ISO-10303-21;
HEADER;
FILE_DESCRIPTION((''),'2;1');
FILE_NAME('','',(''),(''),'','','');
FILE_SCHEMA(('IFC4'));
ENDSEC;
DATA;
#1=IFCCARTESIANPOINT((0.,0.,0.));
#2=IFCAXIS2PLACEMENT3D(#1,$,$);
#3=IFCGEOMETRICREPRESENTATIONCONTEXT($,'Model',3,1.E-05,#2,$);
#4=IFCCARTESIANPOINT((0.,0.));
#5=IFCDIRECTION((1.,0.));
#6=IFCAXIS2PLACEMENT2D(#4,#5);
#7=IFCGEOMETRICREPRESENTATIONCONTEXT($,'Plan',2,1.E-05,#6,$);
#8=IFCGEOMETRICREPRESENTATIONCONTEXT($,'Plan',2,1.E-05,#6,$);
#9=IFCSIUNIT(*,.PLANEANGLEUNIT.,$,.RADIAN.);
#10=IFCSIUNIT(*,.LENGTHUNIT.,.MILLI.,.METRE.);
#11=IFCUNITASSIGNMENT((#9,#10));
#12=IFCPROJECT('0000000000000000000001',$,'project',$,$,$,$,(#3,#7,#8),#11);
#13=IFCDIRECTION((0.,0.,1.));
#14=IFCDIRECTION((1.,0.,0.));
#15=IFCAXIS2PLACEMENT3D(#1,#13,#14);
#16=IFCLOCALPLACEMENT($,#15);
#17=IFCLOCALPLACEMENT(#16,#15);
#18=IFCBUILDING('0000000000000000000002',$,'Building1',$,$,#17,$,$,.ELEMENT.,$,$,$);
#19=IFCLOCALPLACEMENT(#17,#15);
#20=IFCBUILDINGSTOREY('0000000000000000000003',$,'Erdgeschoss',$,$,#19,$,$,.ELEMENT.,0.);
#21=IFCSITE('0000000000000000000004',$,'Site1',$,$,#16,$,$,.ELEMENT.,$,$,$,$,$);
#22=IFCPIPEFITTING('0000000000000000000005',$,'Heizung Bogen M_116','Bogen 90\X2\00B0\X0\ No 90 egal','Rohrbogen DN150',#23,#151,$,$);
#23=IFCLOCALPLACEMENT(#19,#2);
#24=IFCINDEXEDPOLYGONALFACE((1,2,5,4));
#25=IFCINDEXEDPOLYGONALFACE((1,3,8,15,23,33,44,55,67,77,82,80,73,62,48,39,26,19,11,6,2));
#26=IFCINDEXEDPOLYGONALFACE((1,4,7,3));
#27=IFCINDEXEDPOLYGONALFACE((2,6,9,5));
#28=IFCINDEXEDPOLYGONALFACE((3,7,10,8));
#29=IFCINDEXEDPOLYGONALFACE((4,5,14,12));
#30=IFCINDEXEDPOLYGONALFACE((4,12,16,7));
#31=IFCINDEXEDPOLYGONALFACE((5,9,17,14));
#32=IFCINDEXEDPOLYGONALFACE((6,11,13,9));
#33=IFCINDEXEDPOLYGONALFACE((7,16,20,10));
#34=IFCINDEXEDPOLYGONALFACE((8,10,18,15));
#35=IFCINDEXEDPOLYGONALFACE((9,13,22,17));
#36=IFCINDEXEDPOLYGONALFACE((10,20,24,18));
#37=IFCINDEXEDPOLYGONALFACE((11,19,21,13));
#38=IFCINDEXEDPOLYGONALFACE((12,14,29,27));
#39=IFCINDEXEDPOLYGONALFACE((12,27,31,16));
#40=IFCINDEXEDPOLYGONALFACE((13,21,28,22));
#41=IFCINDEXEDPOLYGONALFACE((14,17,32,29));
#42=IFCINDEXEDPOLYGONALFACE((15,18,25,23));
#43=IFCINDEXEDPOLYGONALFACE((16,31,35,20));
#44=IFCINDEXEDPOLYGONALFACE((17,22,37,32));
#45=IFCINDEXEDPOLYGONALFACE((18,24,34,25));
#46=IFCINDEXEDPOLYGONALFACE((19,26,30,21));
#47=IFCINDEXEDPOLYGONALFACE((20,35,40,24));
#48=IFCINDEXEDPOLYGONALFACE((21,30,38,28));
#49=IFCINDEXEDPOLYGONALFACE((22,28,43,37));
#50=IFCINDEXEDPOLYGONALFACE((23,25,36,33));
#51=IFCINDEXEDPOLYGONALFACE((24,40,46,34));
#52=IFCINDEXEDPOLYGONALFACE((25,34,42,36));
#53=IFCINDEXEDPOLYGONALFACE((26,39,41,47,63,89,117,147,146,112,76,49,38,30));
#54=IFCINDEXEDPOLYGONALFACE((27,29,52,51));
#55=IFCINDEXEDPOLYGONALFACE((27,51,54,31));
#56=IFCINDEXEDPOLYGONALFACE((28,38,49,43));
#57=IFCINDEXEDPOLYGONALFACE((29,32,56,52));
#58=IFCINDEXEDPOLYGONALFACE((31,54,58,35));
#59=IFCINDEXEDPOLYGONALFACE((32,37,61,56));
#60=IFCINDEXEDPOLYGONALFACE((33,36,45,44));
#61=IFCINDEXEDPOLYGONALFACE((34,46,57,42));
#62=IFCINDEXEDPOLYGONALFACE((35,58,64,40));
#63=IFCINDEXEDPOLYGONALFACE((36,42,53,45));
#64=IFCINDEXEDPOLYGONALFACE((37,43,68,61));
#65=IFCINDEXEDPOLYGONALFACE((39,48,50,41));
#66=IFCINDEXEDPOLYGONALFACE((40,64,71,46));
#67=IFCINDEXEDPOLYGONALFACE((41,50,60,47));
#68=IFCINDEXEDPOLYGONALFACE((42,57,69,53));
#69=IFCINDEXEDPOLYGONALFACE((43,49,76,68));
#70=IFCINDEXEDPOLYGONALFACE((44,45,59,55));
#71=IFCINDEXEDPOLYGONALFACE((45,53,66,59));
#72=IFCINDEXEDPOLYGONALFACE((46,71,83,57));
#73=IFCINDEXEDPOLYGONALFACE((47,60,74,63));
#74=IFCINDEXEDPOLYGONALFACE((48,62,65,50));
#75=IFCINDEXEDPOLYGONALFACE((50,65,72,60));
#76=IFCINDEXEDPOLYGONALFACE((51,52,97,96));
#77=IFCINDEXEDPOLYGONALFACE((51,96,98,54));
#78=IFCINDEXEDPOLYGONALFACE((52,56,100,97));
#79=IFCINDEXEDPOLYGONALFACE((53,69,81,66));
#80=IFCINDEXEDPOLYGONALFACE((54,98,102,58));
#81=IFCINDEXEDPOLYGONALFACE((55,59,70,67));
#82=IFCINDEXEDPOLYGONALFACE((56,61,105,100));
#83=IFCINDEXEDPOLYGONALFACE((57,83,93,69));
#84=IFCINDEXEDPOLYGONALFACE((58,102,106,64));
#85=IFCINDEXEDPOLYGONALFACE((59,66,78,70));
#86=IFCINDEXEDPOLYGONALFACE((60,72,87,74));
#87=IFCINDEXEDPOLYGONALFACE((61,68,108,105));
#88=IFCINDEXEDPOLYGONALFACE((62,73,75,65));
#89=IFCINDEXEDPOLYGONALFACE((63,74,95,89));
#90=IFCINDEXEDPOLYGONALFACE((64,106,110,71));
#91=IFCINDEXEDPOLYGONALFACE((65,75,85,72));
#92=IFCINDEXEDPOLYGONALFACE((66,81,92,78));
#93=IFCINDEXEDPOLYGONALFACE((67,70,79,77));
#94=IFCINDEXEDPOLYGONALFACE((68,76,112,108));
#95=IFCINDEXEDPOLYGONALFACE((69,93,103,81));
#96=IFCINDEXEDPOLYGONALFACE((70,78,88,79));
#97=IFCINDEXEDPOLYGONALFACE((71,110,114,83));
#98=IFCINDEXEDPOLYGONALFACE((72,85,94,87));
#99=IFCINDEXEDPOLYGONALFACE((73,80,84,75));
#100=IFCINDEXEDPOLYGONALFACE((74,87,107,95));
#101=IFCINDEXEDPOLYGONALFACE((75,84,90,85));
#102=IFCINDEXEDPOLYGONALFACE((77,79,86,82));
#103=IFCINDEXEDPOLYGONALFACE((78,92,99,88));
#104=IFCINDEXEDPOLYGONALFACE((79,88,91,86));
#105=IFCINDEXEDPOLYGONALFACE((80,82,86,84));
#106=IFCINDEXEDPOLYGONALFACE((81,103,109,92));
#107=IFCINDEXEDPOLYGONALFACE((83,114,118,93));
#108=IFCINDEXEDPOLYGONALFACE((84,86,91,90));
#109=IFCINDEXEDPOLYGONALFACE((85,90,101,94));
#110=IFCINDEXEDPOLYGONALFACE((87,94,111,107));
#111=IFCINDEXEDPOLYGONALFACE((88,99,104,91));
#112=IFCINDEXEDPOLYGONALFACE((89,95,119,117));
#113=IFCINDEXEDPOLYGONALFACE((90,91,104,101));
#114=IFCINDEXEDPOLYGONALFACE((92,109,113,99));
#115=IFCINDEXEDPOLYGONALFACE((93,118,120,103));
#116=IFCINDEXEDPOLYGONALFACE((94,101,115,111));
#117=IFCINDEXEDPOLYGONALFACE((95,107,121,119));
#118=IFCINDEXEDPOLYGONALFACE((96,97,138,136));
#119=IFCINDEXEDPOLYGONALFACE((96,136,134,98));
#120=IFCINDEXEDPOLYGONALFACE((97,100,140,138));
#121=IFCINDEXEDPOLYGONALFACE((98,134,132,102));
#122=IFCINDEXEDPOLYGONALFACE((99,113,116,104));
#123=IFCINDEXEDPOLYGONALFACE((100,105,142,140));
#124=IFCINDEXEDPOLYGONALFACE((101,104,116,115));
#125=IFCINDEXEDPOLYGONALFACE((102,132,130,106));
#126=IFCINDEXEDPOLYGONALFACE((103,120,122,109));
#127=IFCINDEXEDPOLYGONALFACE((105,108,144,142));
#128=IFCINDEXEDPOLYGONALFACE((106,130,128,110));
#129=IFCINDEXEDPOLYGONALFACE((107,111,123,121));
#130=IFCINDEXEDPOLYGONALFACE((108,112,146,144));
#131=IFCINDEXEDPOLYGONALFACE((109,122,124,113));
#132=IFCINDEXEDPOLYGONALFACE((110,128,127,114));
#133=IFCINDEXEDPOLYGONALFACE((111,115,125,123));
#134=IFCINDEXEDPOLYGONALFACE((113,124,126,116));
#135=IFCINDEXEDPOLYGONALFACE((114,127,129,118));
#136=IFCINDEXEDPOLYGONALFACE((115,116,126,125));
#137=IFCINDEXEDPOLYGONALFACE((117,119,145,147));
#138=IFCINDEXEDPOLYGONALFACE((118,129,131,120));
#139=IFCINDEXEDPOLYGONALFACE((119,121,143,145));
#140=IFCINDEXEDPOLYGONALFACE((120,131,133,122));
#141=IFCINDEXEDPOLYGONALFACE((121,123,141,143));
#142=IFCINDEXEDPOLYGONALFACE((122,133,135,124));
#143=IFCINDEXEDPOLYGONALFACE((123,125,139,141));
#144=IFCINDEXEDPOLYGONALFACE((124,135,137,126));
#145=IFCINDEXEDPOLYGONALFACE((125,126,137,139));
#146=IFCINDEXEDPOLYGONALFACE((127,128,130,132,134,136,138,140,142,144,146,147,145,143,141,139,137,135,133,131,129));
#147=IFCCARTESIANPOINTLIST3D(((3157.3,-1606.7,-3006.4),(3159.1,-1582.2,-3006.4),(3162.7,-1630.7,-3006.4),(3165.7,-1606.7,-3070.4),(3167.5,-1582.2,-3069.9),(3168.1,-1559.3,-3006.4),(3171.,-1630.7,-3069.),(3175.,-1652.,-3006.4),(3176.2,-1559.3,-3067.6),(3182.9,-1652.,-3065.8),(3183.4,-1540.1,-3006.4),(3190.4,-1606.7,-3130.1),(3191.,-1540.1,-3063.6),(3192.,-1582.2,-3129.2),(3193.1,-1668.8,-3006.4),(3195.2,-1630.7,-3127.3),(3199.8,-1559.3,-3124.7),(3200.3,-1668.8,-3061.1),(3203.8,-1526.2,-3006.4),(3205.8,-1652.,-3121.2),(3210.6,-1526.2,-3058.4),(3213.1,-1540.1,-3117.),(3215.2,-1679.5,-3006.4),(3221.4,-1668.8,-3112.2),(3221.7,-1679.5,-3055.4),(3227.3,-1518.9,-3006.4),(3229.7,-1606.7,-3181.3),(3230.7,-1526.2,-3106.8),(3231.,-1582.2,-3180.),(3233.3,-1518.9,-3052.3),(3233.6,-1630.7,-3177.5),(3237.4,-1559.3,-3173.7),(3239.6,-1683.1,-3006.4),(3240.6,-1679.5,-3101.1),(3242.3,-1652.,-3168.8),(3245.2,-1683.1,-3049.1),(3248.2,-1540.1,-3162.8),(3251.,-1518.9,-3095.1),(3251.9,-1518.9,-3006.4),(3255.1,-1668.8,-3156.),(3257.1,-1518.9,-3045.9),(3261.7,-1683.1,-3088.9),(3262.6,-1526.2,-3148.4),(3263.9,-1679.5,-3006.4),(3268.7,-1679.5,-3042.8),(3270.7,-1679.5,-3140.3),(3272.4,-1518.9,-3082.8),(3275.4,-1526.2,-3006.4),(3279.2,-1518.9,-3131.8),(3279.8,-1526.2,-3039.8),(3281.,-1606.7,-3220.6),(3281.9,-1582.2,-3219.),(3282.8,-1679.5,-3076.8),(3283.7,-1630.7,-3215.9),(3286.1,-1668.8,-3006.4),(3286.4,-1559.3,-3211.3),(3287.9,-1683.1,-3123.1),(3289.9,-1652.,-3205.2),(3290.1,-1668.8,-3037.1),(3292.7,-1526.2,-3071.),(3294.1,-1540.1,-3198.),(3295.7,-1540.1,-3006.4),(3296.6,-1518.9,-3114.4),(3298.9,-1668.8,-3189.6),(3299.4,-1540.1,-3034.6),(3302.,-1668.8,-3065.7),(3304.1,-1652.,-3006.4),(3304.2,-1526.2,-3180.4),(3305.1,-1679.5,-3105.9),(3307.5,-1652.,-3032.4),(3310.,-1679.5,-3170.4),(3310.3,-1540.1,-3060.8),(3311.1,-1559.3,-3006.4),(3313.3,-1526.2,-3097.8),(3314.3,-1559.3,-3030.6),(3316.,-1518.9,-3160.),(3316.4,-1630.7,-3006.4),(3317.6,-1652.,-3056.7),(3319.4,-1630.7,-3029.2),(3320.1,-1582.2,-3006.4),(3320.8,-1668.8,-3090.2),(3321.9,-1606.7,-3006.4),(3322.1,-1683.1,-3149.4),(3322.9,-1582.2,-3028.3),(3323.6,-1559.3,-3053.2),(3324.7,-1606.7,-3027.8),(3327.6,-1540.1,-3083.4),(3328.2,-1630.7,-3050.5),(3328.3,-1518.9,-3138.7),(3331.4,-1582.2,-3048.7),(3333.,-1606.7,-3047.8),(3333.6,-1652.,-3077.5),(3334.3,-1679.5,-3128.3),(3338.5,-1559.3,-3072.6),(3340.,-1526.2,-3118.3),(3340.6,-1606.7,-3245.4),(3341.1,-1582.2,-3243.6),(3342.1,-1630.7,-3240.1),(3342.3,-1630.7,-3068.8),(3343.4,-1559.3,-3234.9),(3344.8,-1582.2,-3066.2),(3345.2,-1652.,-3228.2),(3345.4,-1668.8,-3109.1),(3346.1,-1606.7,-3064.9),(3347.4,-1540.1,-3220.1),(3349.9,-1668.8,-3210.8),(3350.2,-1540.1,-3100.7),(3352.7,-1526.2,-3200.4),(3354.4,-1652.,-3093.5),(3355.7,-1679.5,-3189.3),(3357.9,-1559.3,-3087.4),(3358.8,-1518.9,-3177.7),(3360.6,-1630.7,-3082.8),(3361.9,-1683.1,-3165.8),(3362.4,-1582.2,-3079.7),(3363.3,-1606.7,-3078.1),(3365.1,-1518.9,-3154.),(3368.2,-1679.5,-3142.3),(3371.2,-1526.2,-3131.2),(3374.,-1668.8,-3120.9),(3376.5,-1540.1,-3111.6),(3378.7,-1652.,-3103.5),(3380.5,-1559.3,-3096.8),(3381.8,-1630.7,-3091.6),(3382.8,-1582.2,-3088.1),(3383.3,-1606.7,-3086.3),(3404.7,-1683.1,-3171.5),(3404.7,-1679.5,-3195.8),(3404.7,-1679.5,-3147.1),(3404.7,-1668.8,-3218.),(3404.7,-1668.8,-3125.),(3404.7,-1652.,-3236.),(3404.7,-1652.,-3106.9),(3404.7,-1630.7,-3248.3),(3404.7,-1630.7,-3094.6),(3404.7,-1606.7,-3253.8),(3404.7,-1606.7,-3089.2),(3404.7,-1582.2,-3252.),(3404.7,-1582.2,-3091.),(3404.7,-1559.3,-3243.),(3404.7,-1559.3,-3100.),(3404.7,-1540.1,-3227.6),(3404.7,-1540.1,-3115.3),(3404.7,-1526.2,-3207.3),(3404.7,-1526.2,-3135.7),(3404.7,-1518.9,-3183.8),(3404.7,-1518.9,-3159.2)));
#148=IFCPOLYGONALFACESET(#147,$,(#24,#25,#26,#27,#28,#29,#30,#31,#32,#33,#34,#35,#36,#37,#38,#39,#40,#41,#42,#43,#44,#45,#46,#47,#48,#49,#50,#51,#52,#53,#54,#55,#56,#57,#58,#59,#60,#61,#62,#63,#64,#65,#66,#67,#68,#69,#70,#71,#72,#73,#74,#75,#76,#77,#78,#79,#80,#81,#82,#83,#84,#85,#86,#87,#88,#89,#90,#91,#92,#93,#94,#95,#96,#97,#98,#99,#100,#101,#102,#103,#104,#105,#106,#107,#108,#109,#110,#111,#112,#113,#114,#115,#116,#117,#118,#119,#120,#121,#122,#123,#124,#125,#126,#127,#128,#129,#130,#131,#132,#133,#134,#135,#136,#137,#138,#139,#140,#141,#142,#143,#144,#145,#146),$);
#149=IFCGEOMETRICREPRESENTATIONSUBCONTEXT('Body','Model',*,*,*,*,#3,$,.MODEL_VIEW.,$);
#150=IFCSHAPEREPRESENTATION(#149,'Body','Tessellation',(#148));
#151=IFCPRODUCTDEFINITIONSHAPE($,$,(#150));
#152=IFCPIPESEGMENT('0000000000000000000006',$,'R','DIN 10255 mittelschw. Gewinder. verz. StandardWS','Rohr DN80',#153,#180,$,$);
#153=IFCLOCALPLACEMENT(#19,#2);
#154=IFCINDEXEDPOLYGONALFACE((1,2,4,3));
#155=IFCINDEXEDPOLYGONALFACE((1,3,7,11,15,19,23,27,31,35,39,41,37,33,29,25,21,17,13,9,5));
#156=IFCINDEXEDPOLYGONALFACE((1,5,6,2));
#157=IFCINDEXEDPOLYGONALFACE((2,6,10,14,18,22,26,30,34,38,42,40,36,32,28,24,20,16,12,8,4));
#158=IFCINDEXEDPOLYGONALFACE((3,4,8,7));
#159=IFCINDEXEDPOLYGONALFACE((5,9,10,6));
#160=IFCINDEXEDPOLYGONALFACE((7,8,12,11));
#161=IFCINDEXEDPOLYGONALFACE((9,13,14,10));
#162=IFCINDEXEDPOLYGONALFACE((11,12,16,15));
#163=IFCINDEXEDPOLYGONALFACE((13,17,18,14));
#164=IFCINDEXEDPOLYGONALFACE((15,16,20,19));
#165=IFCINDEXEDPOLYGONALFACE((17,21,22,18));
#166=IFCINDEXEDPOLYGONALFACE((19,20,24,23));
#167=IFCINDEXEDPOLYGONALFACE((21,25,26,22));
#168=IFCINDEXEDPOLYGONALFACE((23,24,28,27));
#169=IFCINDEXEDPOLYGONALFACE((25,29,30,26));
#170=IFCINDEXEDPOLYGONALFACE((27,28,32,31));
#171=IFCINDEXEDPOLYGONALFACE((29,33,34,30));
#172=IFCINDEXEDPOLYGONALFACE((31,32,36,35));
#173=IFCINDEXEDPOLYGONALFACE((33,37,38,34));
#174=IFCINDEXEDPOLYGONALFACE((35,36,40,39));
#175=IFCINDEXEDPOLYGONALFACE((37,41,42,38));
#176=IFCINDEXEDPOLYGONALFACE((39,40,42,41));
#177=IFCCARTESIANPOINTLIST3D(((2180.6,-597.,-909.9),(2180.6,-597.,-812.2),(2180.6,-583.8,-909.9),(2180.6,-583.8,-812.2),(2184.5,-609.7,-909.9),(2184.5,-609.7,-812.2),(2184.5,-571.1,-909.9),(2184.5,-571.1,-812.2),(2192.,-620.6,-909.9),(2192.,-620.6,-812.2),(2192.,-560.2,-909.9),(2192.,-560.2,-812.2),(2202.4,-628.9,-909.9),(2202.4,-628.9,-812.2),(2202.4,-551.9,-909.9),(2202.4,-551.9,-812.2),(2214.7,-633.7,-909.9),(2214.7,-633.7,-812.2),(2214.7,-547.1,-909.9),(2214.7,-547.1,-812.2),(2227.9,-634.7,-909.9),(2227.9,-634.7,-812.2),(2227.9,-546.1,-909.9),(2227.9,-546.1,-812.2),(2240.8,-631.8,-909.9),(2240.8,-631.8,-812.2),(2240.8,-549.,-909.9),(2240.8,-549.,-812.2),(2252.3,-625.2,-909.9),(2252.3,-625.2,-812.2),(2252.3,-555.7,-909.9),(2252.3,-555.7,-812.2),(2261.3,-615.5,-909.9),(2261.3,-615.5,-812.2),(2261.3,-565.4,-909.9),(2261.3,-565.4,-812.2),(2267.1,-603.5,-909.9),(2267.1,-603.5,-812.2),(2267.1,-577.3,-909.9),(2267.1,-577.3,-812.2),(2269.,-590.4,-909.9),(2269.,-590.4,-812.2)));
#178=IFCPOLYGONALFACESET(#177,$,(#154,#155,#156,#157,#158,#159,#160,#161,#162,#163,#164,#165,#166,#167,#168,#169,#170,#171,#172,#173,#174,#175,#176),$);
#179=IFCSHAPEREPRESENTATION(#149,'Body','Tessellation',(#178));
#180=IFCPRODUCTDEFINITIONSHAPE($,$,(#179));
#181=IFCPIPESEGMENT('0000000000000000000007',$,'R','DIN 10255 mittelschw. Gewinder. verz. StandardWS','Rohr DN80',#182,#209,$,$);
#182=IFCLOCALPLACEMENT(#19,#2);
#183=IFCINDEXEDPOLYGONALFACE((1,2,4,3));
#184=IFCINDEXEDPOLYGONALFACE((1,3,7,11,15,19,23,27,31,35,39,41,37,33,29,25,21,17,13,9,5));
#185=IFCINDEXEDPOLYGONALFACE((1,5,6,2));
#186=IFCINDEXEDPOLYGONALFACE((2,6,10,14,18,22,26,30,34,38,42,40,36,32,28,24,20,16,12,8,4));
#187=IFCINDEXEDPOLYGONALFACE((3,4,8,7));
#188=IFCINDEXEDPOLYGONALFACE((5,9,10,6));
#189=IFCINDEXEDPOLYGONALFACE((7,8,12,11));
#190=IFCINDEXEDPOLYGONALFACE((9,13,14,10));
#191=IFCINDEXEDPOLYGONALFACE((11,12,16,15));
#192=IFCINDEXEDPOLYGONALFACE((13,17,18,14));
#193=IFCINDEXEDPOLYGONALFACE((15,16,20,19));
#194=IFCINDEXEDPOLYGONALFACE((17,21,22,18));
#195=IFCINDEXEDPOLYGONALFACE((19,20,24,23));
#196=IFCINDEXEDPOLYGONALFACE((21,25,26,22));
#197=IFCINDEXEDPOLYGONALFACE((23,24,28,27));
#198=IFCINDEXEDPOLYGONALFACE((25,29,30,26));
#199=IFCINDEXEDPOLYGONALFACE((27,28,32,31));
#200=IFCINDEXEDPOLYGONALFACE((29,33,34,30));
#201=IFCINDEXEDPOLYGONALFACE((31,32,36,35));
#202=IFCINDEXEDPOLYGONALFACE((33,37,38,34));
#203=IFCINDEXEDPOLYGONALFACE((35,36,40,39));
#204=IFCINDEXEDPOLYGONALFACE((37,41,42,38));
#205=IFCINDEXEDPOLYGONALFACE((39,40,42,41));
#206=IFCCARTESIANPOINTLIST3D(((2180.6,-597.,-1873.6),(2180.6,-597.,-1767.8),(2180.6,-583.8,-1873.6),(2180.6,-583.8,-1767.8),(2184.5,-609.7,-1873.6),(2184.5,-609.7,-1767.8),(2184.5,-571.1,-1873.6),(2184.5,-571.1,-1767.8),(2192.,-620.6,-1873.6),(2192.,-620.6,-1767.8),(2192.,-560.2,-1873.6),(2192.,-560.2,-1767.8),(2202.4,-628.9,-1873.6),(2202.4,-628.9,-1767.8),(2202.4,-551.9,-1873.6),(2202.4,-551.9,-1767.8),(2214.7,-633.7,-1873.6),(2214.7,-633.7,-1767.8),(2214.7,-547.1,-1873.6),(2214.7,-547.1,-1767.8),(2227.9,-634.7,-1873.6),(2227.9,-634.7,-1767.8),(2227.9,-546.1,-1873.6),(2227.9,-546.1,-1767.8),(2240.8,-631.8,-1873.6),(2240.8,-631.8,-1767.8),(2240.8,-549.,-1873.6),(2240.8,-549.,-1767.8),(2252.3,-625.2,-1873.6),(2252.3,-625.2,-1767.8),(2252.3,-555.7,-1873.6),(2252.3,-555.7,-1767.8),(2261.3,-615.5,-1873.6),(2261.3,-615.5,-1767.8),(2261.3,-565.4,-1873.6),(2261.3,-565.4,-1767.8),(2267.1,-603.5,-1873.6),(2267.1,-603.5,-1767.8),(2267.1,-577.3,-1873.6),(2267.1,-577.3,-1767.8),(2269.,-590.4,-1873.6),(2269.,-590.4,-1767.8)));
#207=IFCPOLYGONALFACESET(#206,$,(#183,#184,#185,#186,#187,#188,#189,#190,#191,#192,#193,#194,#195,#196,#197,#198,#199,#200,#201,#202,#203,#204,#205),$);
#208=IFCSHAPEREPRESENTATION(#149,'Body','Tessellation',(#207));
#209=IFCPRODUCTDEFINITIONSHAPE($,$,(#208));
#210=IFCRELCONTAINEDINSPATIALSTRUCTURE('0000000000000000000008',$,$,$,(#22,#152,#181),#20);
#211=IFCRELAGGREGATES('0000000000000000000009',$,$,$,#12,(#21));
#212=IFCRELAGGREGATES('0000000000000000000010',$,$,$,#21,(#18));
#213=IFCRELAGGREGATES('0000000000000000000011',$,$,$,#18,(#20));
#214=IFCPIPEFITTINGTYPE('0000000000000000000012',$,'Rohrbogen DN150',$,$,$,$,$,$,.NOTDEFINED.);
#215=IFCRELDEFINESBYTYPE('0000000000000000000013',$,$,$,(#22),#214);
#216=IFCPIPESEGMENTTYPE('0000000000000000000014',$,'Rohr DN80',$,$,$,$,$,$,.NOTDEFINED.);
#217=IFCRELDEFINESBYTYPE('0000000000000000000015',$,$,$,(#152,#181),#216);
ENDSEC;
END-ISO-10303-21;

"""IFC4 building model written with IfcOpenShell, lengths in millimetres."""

from ifc_helpers import new_model, entity, si_unit, frame, origin, origin_with_axes, origin_2d_with_axis, place, context, subcontext, project, spatial, circle, extrude, source, transform, mapped, type_object, element, save


model = new_model("IFC4")

# Units and contexts
model_context = context("Model", 3, precision=1e-05, world=origin())
plan_context_1 = context("Plan", 2, precision=1e-05, world=origin_2d_with_axis())
plan_context_2 = context("Plan", 2, precision=1e-05, world=origin_2d_with_axis())
body_context = subcontext(model_context, "Body", "Model", "MODEL_VIEW")
ifc_project = project(units=[si_unit("PLANEANGLEUNIT", "RADIAN"), si_unit("LENGTHUNIT", "METRE", prefix="MILLI")], contexts=[model_context, plan_context_1, plan_context_2])

# Site, building, storey
site_placement = place(None, origin_with_axes())
site = spatial("IfcSite", under=ifc_project, at=site_placement, Name="Site1", CompositionType="ELEMENT")
building_placement = place(site_placement, origin_with_axes())
building = spatial("IfcBuilding", under=site, at=building_placement, Name="Building1", CompositionType="ELEMENT")
storey_placement = place(building_placement, origin_with_axes())
storey = spatial("IfcBuildingStorey", under=building, at=storey_placement, Name="Erdgeschoss", CompositionType="ELEMENT", Elevation=0.0)

# Pipe fitting
pipe_fitting_type_1 = type_object("IfcPipeFittingType", Name="Rohrbogen DN150", PredefinedType="NOTDEFINED")
shared_shape_1 = source(origin_with_axes(), body_context, "Body", "SolidModel", [
    entity("IfcRevolvedAreaSolid", entity("IfcCircleProfileDef", "AREA", None, entity("IfcAxis2Placement2D", entity("IfcCartesianPoint", [0.0, 0.0]), entity("IfcDirection", [1.0, 0.0])), 82.5), entity("IfcAxis2Placement3D", entity("IfcCartesianPoint", [123.8, 41.3, 0.0]), entity("IfcDirection", [-1.0, 0.0, 0.0]), entity("IfcDirection", [0.0, 0.0, -1.0])), entity("IfcAxis1Placement", entity("IfcCartesianPoint", [0.0, 165.1, 0.0]), entity("IfcDirection", [-1.0, 0.0, 0.0])), 1.570796),
])
pipe_fitting_1_placement = place(storey_placement, frame((3280.9, -1600.6, -3130.2), z_axis=(0.0, 0.0, 1.0), x_axis=(1.0, 0.0, 0.0)))
element("IfcPipeFitting", 1, at=pipe_fitting_1_placement, inside=storey, type_object=pipe_fitting_type_1, Name="Heizung Bogen M_116", Description="Bogen 90° No 90 egal", ObjectType="Rohrbogen DN150", context=body_context, shape_type="MappedRepresentation", body=[
    mapped(shared_shape_1, transform((0.0, 0.0, 0.0), x_axis=(1.0, 0.0, 0.0), y_axis=(0.0, 0.0, -1.0), z_axis=(0.0, 1.0, 0.0), scale=1.0)),
])

# Pipe segments
pipe_segment_type_1 = type_object("IfcPipeSegmentType", Name="Rohr DN80", PredefinedType="NOTDEFINED")
pipe_segment_1_placement = place(storey_placement, frame((2224.6, -590.6, -861.0), z_axis=(0.0, 0.0, 1.0), x_axis=(1.0, 0.0, 0.0)))
element("IfcPipeSegment", 2, at=pipe_segment_1_placement, inside=storey, type_object=pipe_segment_type_1, Name="R", Description="DIN 10255 mittelschw. Gewinder. verz. StandardWS", ObjectType="Rohr DN80", context=body_context, shape_type="SolidModel", body=[
    extrude(circle(Radius=44.5, at=origin_2d_with_axis()), frame((0.0, 0.1, -48.8), z_axis=(0.0, 0.0, 1.0), x_axis=(1.0, 0.0, 0.0)), (0.0, 0.0, 1.0), 97.7),
])
pipe_segment_2_placement = place(storey_placement, frame((2224.6, -590.6, -1820.7), z_axis=(0.0, 0.0, 1.0), x_axis=(1.0, 0.0, 0.0)))
element("IfcPipeSegment", 3, at=pipe_segment_2_placement, inside=storey, type_object=pipe_segment_type_1, Name="R", Description="DIN 10255 mittelschw. Gewinder. verz. StandardWS", ObjectType="Rohr DN80", context=body_context, shape_type="SolidModel", body=[
    extrude(circle(Radius=44.5, at=origin_2d_with_axis()), frame((0.0, 0.1, -52.9), z_axis=(0.0, 0.0, 1.0), x_axis=(1.0, 0.0, 0.0)), (0.0, 0.0, 1.0), 105.8),
])

save(model, "model.ifc")
